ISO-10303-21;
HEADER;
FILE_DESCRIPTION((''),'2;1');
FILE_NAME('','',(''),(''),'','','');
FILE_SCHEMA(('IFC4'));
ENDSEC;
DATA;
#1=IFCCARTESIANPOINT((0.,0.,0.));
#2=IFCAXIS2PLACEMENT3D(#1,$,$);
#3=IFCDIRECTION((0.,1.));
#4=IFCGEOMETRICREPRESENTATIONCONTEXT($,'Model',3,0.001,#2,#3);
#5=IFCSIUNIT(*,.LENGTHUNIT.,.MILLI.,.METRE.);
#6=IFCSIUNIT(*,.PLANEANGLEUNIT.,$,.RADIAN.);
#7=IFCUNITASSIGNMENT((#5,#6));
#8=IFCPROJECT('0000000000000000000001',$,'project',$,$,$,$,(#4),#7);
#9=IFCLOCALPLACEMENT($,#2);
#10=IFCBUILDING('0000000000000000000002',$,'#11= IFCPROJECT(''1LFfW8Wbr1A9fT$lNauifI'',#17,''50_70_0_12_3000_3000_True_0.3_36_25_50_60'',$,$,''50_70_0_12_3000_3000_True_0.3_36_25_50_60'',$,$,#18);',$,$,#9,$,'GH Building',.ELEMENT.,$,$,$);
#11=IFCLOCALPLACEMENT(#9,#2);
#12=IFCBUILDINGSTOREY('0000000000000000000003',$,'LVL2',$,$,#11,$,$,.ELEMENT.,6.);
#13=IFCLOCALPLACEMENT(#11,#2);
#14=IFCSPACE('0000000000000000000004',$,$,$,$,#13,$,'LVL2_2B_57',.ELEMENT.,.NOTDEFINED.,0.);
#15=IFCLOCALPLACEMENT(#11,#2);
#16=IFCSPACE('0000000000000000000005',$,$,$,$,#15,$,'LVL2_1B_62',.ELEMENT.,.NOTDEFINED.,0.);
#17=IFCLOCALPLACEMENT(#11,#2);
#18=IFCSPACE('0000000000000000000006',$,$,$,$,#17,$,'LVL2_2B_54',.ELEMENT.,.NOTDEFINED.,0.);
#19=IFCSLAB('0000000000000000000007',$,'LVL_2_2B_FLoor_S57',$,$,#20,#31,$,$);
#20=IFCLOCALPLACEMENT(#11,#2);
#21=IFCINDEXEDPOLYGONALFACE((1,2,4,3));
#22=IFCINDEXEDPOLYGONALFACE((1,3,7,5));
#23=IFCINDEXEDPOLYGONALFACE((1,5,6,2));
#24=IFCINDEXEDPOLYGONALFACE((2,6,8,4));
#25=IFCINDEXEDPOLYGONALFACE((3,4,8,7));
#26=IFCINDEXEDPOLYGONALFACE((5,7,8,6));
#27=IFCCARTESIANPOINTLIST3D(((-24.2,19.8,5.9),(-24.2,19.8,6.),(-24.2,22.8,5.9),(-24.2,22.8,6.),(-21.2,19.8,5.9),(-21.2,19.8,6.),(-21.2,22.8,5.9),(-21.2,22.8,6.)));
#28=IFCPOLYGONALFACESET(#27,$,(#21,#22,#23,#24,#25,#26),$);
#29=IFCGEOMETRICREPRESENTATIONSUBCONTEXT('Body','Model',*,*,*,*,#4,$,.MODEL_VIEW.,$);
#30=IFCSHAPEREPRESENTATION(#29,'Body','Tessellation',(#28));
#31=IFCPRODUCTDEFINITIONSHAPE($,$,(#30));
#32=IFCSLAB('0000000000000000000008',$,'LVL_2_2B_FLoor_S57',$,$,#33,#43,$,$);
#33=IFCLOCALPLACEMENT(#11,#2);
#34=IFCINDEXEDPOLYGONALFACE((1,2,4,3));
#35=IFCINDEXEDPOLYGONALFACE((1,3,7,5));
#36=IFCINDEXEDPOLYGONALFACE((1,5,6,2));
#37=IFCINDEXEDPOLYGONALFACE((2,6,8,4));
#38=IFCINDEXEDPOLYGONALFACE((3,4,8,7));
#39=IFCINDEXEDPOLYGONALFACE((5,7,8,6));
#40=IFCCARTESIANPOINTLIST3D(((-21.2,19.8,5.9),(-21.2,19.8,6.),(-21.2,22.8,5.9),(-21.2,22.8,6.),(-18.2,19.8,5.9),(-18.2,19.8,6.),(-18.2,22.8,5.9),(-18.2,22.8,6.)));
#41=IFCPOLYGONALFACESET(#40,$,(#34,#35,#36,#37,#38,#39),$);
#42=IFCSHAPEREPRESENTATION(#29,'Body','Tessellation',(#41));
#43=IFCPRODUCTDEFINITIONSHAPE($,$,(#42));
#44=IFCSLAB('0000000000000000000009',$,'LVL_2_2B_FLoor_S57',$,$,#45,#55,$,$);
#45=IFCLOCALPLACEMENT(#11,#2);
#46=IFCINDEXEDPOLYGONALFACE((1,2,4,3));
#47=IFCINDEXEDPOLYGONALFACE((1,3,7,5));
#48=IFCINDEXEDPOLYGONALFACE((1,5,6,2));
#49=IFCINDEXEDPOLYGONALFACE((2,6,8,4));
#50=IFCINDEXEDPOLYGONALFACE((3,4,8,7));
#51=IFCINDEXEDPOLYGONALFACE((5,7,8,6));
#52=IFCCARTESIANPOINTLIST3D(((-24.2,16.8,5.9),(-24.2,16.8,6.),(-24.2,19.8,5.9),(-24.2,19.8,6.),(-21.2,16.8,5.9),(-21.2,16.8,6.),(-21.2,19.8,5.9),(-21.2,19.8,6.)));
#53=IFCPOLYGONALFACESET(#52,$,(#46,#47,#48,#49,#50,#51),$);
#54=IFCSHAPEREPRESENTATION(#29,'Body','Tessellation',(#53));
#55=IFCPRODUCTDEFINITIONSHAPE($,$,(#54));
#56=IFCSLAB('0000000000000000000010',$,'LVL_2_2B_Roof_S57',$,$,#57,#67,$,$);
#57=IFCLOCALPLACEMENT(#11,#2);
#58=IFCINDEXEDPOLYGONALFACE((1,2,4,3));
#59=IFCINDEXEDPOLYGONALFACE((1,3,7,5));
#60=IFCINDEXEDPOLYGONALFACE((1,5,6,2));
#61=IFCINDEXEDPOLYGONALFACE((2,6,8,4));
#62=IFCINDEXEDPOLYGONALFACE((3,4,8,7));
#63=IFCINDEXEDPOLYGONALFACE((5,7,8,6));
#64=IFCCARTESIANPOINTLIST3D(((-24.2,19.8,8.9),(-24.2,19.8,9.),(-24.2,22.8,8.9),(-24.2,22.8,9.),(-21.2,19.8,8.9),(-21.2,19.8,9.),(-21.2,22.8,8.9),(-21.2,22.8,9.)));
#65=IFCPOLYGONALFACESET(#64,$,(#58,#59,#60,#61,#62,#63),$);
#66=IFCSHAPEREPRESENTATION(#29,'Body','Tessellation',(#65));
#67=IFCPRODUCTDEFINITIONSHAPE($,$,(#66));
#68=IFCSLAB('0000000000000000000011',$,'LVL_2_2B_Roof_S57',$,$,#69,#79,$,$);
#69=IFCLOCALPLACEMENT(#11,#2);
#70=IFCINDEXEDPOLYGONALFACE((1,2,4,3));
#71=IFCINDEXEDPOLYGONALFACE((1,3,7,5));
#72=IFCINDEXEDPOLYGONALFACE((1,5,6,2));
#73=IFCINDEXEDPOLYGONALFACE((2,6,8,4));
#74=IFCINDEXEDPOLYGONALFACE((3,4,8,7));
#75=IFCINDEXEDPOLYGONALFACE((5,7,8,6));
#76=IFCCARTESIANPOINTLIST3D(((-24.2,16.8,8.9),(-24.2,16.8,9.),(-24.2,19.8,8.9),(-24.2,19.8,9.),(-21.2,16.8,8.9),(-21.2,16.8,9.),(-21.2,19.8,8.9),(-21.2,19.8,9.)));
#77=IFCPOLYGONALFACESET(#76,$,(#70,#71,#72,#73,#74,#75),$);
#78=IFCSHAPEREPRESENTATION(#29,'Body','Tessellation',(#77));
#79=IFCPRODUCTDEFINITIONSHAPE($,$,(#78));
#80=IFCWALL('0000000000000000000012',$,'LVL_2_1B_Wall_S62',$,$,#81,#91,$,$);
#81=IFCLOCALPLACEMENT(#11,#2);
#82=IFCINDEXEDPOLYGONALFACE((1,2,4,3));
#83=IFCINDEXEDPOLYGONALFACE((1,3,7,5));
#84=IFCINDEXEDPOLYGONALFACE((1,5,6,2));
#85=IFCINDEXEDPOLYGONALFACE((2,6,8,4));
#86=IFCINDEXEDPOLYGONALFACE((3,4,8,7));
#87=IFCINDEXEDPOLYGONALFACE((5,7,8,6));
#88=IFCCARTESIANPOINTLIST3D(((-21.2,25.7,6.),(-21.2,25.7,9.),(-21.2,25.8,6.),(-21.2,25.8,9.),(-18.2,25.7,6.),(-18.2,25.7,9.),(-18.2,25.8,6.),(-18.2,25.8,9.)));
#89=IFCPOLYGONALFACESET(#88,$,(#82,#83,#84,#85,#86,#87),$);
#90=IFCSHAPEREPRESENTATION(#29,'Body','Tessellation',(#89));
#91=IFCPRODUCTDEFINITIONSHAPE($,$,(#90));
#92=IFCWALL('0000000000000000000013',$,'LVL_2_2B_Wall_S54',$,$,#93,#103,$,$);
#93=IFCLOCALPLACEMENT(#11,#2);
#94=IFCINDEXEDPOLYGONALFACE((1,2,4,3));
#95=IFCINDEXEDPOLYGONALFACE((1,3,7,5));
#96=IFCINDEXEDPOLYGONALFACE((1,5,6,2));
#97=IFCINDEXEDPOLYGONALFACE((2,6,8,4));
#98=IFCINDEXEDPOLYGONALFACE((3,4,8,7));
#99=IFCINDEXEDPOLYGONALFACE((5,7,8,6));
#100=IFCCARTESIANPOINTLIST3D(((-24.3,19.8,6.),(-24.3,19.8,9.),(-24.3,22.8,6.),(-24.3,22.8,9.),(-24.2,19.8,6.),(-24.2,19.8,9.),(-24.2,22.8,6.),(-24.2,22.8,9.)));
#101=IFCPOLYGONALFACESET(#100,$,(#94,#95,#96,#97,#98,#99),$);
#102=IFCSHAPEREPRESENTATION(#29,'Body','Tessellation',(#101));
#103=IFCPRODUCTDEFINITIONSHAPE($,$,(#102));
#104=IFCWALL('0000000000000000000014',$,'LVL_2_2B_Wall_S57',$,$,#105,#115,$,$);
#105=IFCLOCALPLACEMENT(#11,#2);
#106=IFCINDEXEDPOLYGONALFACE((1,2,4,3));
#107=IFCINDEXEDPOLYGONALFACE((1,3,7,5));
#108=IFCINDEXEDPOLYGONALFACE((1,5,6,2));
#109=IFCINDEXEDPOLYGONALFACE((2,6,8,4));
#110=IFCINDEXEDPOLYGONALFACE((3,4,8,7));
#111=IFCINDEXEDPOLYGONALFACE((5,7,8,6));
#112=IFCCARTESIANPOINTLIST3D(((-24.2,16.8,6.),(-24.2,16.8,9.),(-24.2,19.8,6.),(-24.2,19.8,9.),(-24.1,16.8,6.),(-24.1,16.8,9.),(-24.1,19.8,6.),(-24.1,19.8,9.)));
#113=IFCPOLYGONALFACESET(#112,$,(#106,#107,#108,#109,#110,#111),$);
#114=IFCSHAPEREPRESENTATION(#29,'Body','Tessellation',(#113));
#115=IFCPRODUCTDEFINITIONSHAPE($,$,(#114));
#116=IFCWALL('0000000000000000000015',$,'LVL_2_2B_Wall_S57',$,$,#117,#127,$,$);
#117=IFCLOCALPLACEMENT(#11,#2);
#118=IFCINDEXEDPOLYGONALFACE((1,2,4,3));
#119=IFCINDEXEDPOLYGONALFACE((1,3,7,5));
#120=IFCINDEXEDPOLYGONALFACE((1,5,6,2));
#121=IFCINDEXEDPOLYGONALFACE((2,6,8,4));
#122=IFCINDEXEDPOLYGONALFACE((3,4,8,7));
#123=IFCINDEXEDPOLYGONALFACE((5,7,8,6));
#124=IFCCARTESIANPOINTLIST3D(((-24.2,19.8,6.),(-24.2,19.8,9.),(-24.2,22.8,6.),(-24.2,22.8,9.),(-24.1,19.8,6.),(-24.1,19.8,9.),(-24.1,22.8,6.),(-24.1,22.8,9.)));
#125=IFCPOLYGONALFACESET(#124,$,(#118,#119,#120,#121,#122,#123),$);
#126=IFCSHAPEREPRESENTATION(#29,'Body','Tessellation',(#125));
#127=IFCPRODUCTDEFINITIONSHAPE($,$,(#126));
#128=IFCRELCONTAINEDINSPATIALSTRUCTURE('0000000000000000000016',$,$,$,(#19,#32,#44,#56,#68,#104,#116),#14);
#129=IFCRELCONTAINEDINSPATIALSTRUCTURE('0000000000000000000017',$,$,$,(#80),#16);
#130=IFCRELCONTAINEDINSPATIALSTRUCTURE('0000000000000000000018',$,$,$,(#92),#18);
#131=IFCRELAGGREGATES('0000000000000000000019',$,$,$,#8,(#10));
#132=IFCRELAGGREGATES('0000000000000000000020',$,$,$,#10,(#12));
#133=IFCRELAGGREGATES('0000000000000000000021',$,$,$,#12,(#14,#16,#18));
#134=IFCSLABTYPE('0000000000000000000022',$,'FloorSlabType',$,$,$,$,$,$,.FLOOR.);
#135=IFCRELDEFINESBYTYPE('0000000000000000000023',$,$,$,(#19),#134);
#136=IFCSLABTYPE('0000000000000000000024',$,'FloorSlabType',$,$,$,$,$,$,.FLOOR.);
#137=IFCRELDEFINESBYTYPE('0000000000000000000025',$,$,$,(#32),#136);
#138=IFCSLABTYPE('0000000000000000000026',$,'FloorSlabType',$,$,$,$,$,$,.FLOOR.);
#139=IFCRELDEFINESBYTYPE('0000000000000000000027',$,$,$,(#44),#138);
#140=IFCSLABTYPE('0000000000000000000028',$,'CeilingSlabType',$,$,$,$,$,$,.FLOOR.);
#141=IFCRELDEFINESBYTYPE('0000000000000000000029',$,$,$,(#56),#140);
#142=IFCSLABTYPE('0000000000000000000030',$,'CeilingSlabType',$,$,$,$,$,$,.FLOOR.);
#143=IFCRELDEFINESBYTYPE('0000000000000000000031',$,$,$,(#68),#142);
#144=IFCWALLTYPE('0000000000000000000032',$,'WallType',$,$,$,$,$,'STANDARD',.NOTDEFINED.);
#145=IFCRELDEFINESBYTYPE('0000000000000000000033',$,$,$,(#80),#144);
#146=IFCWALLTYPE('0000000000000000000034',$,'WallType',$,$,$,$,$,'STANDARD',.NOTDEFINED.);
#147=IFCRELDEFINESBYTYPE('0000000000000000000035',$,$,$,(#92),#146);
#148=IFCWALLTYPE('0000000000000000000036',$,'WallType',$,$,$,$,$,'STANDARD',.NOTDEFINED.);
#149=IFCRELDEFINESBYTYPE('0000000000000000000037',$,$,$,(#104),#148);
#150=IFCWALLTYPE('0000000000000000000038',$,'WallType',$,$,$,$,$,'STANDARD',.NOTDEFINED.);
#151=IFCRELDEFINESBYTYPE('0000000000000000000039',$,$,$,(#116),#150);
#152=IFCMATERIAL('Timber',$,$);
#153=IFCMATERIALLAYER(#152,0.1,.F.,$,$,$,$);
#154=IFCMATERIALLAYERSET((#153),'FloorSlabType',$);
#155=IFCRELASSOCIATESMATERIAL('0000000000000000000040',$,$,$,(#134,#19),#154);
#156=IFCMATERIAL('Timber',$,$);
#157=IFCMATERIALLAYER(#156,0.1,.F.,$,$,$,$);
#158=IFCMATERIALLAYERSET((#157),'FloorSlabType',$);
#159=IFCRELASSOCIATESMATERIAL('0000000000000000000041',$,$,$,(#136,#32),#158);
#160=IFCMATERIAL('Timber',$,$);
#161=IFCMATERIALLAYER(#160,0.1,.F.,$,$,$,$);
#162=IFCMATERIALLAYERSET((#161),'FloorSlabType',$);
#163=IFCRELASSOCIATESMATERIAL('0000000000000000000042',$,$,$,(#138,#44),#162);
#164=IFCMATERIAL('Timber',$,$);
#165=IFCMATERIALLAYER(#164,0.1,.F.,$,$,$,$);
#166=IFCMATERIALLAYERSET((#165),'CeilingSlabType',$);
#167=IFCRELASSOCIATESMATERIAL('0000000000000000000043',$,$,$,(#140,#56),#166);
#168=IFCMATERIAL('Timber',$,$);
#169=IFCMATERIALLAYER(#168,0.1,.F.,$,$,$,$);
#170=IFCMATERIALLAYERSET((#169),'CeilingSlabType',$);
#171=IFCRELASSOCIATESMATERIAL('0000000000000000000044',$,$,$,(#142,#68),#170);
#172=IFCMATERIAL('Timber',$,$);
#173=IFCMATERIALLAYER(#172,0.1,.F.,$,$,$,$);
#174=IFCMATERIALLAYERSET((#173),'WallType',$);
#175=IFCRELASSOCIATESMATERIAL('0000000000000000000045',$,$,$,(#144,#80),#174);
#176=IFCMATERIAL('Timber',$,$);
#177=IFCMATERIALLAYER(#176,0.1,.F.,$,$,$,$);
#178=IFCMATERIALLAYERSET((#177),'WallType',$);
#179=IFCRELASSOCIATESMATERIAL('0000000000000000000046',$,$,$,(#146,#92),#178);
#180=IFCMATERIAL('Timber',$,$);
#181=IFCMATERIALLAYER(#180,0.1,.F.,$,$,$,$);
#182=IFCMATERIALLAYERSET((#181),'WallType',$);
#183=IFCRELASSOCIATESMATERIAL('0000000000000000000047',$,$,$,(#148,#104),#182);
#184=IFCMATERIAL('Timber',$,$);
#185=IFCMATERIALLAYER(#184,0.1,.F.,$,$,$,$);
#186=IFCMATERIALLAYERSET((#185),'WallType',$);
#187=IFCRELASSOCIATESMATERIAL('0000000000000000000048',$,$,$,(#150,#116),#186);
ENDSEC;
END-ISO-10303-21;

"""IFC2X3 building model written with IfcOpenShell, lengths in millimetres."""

from ifc_helpers import new_model, si_unit, direction, frame, frame_2d, origin, place, context, subcontext, project, spatial, rectangle, extrude, material, layer, layer_set, layer_usage, type_object, element, save


model = new_model("IFC2X3")

# Units and contexts
model_context = context("Model", 3, precision=0.001, world=origin(), true_north=direction((0.0, 1.0)))
body_context = subcontext(model_context, "Body", "Model", "MODEL_VIEW")
ifc_project = project(units=[si_unit("LENGTHUNIT", "METRE", prefix="MILLI"), si_unit("PLANEANGLEUNIT", "RADIAN")], contexts=[model_context])

# Building, storey
building_placement = place(None, origin())
building = spatial("IfcBuilding", under=ifc_project, at=building_placement, Name="#11= IFCPROJECT('1LFfW8Wbr1A9fT$lNauifI',#17,'50_70_0_12_3000_3000_True_0.3_36_25_50_60',$,$,'50_70_0_12_3000_3000_True_0.3_36_25_50_60',$,$,#18);", LongName="GH Building", CompositionType="ELEMENT")
storey_placement = place(building_placement, origin())
storey = spatial("IfcBuildingStorey", under=building, at=storey_placement, Name="LVL2", CompositionType="ELEMENT", Elevation=6.0)

# Shared definitions
space_1_placement = place(storey_placement, origin())
space_1 = spatial("IfcSpace", under=storey, at=space_1_placement, LongName="LVL2_2B_57", CompositionType="ELEMENT", InteriorOrExteriorSpace="NOTDEFINED", ElevationWithFlooring=0.0)

# Slabs
ifc_material_1 = material(Name="Timber")
ifc_layer_1 = layer(ifc_material_1, 0.1, ventilated=False)
ifc_layer_set_1 = layer_set([ifc_layer_1], Name="FloorSlabType")
ifc_layer_usage_1 = layer_usage(ifc_layer_set_1, "AXIS3", "NEGATIVE", -0.1)
slab_type_1 = type_object("IfcSlabType", Name="FloorSlabType", PredefinedType="FLOOR", material=ifc_layer_set_1)
slab_1_placement = place(space_1_placement, frame((-24.2, 19.8, 5.9)))
element("IfcSlab", 1, at=slab_1_placement, inside=space_1, type_object=slab_type_1, material=ifc_layer_usage_1, Name="LVL_2_2B_FLoor_S57", context=body_context, shape_type="SweptSolid", body=[
    extrude(rectangle(XDim=3.0, YDim=3.0, at=frame_2d((1.5, 1.5))), origin(), (0.0, 0.0, 1.0), 0.1),
])
ifc_material_2 = material(Name="Timber")
ifc_layer_2 = layer(ifc_material_2, 0.1, ventilated=False)
ifc_layer_set_2 = layer_set([ifc_layer_2], Name="FloorSlabType")
ifc_layer_usage_2 = layer_usage(ifc_layer_set_2, "AXIS3", "NEGATIVE", -0.1)
slab_type_2 = type_object("IfcSlabType", Name="FloorSlabType", PredefinedType="FLOOR", material=ifc_layer_set_2)
slab_2_placement = place(space_1_placement, frame((-21.2, 19.8, 5.9)))
element("IfcSlab", 2, at=slab_2_placement, inside=space_1, type_object=slab_type_2, material=ifc_layer_usage_2, Name="LVL_2_2B_FLoor_S57", context=body_context, shape_type="SweptSolid", body=[
    extrude(rectangle(XDim=3.0, YDim=3.0, at=frame_2d((1.5, 1.5))), origin(), (0.0, 0.0, 1.0), 0.1),
])
ifc_material_3 = material(Name="Timber")
ifc_layer_3 = layer(ifc_material_3, 0.1, ventilated=False)
ifc_layer_set_3 = layer_set([ifc_layer_3], Name="FloorSlabType")
ifc_layer_usage_3 = layer_usage(ifc_layer_set_3, "AXIS3", "NEGATIVE", -0.1)
slab_type_3 = type_object("IfcSlabType", Name="FloorSlabType", PredefinedType="FLOOR", material=ifc_layer_set_3)
slab_3_placement = place(space_1_placement, frame((-24.2, 16.8, 5.9)))
element("IfcSlab", 3, at=slab_3_placement, inside=space_1, type_object=slab_type_3, material=ifc_layer_usage_3, Name="LVL_2_2B_FLoor_S57", context=body_context, shape_type="SweptSolid", body=[
    extrude(rectangle(XDim=3.0, YDim=3.0, at=frame_2d((1.5, 1.5))), origin(), (0.0, 0.0, 1.0), 0.1),
])
ifc_material_4 = material(Name="Timber")
ifc_layer_4 = layer(ifc_material_4, 0.1, ventilated=False)
ifc_layer_set_4 = layer_set([ifc_layer_4], Name="CeilingSlabType")
ifc_layer_usage_4 = layer_usage(ifc_layer_set_4, "AXIS3", "NEGATIVE", -0.1)
slab_type_4 = type_object("IfcSlabType", Name="CeilingSlabType", PredefinedType="FLOOR", material=ifc_layer_set_4)
slab_4_placement = place(space_1_placement, frame((-24.2, 19.8, 8.9)))
element("IfcSlab", 4, at=slab_4_placement, inside=space_1, type_object=slab_type_4, material=ifc_layer_usage_4, Name="LVL_2_2B_Roof_S57", context=body_context, shape_type="SweptSolid", body=[
    extrude(rectangle(XDim=3.0, YDim=3.0, at=frame_2d((1.5, 1.5))), origin(), (0.0, 0.0, 1.0), 0.1),
])
ifc_material_5 = material(Name="Timber")
ifc_layer_5 = layer(ifc_material_5, 0.1, ventilated=False)
ifc_layer_set_5 = layer_set([ifc_layer_5], Name="CeilingSlabType")
ifc_layer_usage_5 = layer_usage(ifc_layer_set_5, "AXIS3", "NEGATIVE", -0.1)
slab_type_5 = type_object("IfcSlabType", Name="CeilingSlabType", PredefinedType="FLOOR", material=ifc_layer_set_5)
slab_5_placement = place(space_1_placement, frame((-24.2, 16.8, 8.9)))
element("IfcSlab", 5, at=slab_5_placement, inside=space_1, type_object=slab_type_5, material=ifc_layer_usage_5, Name="LVL_2_2B_Roof_S57", context=body_context, shape_type="SweptSolid", body=[
    extrude(rectangle(XDim=3.0, YDim=3.0, at=frame_2d((1.5, 1.5))), origin(), (0.0, 0.0, 1.0), 0.1),
])

# Shared definitions
space_2_placement = place(storey_placement, origin())
space_2 = spatial("IfcSpace", under=storey, at=space_2_placement, LongName="LVL2_1B_62", CompositionType="ELEMENT", InteriorOrExteriorSpace="NOTDEFINED", ElevationWithFlooring=0.0)

# Wall
ifc_material_6 = material(Name="Timber")
ifc_layer_6 = layer(ifc_material_6, 0.1, ventilated=False)
ifc_layer_set_6 = layer_set([ifc_layer_6], Name="WallType")
ifc_layer_usage_6 = layer_usage(ifc_layer_set_6, "AXIS2", "NEGATIVE", 0.0)
wall_type_1 = type_object("IfcWallType", Name="WallType", ElementType="STANDARD", PredefinedType="NOTDEFINED", material=ifc_layer_set_6)
wall_1_placement = place(space_2_placement, frame((-21.2, 25.8, 6.0)))
element("IfcWall", 6, at=wall_1_placement, inside=space_2, type_object=wall_type_1, material=ifc_layer_usage_6, Name="LVL_2_1B_Wall_S62", context=body_context, shape_type="SweptSolid", body=[
    extrude(rectangle(XDim=3.0, YDim=0.1, at=frame_2d((1.5, -0.1))), origin(), (0.0, 0.0, 1.0), 3.0),
])

# Shared definitions
space_3_placement = place(storey_placement, origin())
space_3 = spatial("IfcSpace", under=storey, at=space_3_placement, LongName="LVL2_2B_54", CompositionType="ELEMENT", InteriorOrExteriorSpace="NOTDEFINED", ElevationWithFlooring=0.0)

# Walls
ifc_material_7 = material(Name="Timber")
ifc_layer_7 = layer(ifc_material_7, 0.1, ventilated=False)
ifc_layer_set_7 = layer_set([ifc_layer_7], Name="WallType")
ifc_layer_usage_7 = layer_usage(ifc_layer_set_7, "AXIS2", "NEGATIVE", 0.0)
wall_type_2 = type_object("IfcWallType", Name="WallType", ElementType="STANDARD", PredefinedType="NOTDEFINED", material=ifc_layer_set_7)
wall_2_placement = place(space_3_placement, frame((-24.2, 22.8, 6.0), z_axis=(0.0, 0.0, 1.0), x_axis=(0.0, -1.0, 0.0)))
element("IfcWall", 7, at=wall_2_placement, inside=space_3, type_object=wall_type_2, material=ifc_layer_usage_7, Name="LVL_2_2B_Wall_S54", context=body_context, shape_type="SweptSolid", body=[
    extrude(rectangle(XDim=3.0, YDim=0.1, at=frame_2d((1.5, -0.1))), origin(), (0.0, 0.0, 1.0), 3.0),
])
ifc_material_8 = material(Name="Timber")
ifc_layer_8 = layer(ifc_material_8, 0.1, ventilated=False)
ifc_layer_set_8 = layer_set([ifc_layer_8], Name="WallType")
ifc_layer_usage_8 = layer_usage(ifc_layer_set_8, "AXIS2", "NEGATIVE", 0.0)
wall_type_3 = type_object("IfcWallType", Name="WallType", ElementType="STANDARD", PredefinedType="NOTDEFINED", material=ifc_layer_set_8)
wall_3_placement = place(space_1_placement, frame((-24.2, 16.8, 6.0), z_axis=(0.0, 0.0, 1.0), x_axis=(0.0, 1.0, 0.0)))
element("IfcWall", 8, at=wall_3_placement, inside=space_1, type_object=wall_type_3, material=ifc_layer_usage_8, Name="LVL_2_2B_Wall_S57", context=body_context, shape_type="SweptSolid", body=[
    extrude(rectangle(XDim=3.0, YDim=0.1, at=frame_2d((1.5, -0.1))), origin(), (0.0, 0.0, 1.0), 3.0),
])
ifc_material_9 = material(Name="Timber")
ifc_layer_9 = layer(ifc_material_9, 0.1, ventilated=False)
ifc_layer_set_9 = layer_set([ifc_layer_9], Name="WallType")
ifc_layer_usage_9 = layer_usage(ifc_layer_set_9, "AXIS2", "NEGATIVE", 0.0)
wall_type_4 = type_object("IfcWallType", Name="WallType", ElementType="STANDARD", PredefinedType="NOTDEFINED", material=ifc_layer_set_9)
wall_4_placement = place(space_1_placement, frame((-24.2, 19.8, 6.0), z_axis=(0.0, 0.0, 1.0), x_axis=(0.0, 1.0, 0.0)))
element("IfcWall", 9, at=wall_4_placement, inside=space_1, type_object=wall_type_4, material=ifc_layer_usage_9, Name="LVL_2_2B_Wall_S57", context=body_context, shape_type="SweptSolid", body=[
    extrude(rectangle(XDim=3.0, YDim=0.1, at=frame_2d((1.5, -0.1))), origin(), (0.0, 0.0, 1.0), 3.0),
])

save(model, "model.ifc")
